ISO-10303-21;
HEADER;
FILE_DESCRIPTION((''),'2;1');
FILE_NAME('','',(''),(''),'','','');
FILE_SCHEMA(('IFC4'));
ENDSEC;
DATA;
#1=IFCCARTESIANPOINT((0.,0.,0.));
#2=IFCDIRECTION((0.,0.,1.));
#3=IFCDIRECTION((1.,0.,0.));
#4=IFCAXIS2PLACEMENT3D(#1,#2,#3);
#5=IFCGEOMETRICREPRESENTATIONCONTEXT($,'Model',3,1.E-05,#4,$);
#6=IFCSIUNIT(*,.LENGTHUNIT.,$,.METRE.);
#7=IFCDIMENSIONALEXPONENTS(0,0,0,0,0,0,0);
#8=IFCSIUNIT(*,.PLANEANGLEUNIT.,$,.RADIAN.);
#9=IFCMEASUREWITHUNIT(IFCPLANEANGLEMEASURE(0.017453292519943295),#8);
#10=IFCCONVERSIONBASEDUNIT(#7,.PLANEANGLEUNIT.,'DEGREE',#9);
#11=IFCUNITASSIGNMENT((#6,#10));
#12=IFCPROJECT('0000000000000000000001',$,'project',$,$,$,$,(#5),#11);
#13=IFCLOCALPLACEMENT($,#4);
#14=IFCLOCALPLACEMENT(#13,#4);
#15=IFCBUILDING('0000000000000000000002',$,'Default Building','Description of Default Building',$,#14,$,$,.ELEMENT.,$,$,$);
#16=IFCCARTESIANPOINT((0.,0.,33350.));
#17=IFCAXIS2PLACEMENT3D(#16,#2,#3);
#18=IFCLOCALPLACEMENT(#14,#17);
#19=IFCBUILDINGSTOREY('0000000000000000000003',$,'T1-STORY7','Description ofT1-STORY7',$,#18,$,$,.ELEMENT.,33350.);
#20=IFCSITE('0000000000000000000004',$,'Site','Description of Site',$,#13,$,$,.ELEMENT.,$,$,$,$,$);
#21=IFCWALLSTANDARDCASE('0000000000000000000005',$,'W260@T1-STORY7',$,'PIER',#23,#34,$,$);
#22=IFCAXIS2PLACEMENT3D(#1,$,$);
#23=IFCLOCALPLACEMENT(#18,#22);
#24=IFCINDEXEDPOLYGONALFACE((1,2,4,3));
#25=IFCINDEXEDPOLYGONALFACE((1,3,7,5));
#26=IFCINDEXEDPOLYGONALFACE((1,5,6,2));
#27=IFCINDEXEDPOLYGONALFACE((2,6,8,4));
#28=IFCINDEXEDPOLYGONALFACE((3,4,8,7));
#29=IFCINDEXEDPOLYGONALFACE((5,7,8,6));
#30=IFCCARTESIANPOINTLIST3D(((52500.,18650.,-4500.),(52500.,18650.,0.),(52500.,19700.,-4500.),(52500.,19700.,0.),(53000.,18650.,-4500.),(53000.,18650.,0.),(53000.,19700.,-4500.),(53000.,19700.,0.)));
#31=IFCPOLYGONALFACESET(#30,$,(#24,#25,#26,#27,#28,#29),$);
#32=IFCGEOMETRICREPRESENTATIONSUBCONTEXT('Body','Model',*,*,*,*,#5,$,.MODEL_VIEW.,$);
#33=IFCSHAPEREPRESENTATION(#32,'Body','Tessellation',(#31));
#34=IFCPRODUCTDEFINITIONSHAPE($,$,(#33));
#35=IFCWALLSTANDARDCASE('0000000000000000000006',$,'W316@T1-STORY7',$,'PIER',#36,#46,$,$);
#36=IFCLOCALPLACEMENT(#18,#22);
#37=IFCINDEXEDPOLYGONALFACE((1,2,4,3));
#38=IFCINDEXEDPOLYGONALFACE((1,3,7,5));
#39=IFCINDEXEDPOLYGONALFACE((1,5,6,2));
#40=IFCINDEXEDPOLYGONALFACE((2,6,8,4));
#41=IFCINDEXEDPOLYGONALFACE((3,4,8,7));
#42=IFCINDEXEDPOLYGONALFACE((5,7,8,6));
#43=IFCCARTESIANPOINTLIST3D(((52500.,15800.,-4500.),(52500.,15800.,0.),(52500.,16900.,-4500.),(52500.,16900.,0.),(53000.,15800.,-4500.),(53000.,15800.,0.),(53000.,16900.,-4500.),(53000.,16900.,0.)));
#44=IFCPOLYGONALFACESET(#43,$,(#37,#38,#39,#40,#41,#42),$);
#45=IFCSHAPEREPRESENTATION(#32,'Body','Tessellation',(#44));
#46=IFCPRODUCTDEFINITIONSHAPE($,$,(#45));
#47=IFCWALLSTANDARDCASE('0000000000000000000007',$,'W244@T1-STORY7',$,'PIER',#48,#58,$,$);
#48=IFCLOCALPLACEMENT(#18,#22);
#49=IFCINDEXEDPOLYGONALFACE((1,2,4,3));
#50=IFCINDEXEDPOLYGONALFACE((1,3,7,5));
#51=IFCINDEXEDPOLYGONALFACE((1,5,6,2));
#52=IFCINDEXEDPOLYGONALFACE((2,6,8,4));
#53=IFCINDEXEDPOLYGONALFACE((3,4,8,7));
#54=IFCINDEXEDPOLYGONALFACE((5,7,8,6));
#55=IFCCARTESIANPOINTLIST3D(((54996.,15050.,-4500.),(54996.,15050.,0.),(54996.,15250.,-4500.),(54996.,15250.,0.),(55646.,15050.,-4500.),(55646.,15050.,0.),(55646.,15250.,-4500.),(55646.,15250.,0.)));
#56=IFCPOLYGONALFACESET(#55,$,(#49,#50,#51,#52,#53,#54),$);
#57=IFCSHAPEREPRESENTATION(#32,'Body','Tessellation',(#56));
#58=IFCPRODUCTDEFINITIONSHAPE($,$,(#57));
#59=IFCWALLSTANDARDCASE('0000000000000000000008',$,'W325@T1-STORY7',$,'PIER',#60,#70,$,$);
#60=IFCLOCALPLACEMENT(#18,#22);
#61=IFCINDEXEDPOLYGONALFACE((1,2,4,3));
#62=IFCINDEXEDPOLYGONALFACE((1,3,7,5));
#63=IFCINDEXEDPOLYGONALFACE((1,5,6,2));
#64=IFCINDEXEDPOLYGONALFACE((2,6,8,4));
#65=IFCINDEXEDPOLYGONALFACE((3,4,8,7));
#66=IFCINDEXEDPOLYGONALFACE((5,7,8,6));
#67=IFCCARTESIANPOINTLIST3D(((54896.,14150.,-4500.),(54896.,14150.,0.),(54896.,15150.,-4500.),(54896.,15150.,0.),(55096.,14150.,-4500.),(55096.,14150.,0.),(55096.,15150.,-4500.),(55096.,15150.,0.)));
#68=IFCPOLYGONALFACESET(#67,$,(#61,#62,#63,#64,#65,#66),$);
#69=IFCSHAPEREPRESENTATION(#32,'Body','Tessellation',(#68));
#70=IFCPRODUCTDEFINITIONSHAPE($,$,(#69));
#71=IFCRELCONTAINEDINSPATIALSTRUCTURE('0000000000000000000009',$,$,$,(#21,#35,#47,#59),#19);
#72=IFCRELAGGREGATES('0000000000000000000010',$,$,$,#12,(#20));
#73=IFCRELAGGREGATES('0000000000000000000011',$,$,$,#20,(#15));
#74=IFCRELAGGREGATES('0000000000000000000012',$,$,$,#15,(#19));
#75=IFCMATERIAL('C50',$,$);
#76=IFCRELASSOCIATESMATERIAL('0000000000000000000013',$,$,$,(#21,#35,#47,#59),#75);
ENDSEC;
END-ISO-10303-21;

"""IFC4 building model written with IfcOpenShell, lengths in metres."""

from ifc_helpers import new_model, entity, si_unit, converted_unit, frame, origin_with_axes, place, context, subcontext, project, spatial, indexed_curve, outline, extrude, material, element, save


model = new_model("IFC4")

# Units and contexts
model_context = context("Model", 3, precision=1e-05, world=origin_with_axes())
body_context = subcontext(model_context, "Body", "Model", "MODEL_VIEW")
ifc_project = project(units=[si_unit("LENGTHUNIT", "METRE"), converted_unit("PLANEANGLEUNIT", "DEGREE", entity("IfcPlaneAngleMeasure", 0.017453292519943295), si_unit("PLANEANGLEUNIT", "RADIAN"), dimensions=[0, 0, 0, 0, 0, 0, 0])], contexts=[model_context])

# Site, building, storey
site_placement = place(None, origin_with_axes())
site = spatial("IfcSite", under=ifc_project, at=site_placement, Name="Site", Description="Description of Site", CompositionType="ELEMENT")
building_placement = place(site_placement, origin_with_axes())
building = spatial("IfcBuilding", under=site, at=building_placement, Name="Default Building", Description="Description of Default Building", CompositionType="ELEMENT")
storey_placement = place(building_placement, frame((0.0, 0.0, 33350.0), z_axis=(0.0, 0.0, 1.0), x_axis=(1.0, 0.0, 0.0)))
storey = spatial("IfcBuildingStorey", under=building, at=storey_placement, Name="T1-STORY7", Description="Description ofT1-STORY7", CompositionType="ELEMENT", Elevation=33350.0)

# Shared definitions
ifc_material_1 = material(Name="C50")

# Walls
wall_1_placement = place(storey_placement, frame((52750.0, 18650.0, -4500.0), z_axis=(0.0, 0.0, 1.0), x_axis=(0.0, 1.0, 0.0)))
element("IfcWallStandardCase", 1, at=wall_1_placement, inside=storey, material=ifc_material_1, Name="W260@T1-STORY7", ObjectType="PIER", context=body_context, shape_type="SweptSolid", body=[
    extrude(outline(indexed_curve([(0.0, -250.0), (0.0, 250.0), (1050.0, 250.0), (1050.0, -250.0), (0.0, -250.0)], self_intersect=False)), origin_with_axes(), (0.0, 0.0, 1.0), 4500.0),
])
wall_2_placement = place(storey_placement, frame((52750.0, 15800.0, -4500.0), z_axis=(0.0, 0.0, 1.0), x_axis=(0.0, 1.0, 0.0)))
element("IfcWallStandardCase", 2, at=wall_2_placement, inside=storey, material=ifc_material_1, Name="W316@T1-STORY7", ObjectType="PIER", context=body_context, shape_type="SweptSolid", body=[
    extrude(outline(indexed_curve([(0.0, -250.0), (0.0, 250.0), (1100.0, 250.0), (1100.0, -250.0), (0.0, -250.0)], self_intersect=False)), origin_with_axes(), (0.0, 0.0, 1.0), 4500.0),
])
wall_3_placement = place(storey_placement, frame((54996.0, 15150.0, -4500.0), z_axis=(0.0, 0.0, 1.0), x_axis=(1.0, 0.0, 0.0)))
element("IfcWallStandardCase", 3, at=wall_3_placement, inside=storey, material=ifc_material_1, Name="W244@T1-STORY7", ObjectType="PIER", context=body_context, shape_type="SweptSolid", body=[
    extrude(outline(indexed_curve([(0.0, -100.0), (0.0, 100.0), (650.0, 100.0), (650.0, -100.0), (0.0, -100.0)], self_intersect=False)), origin_with_axes(), (0.0, 0.0, 1.0), 4500.0),
])
wall_4_placement = place(storey_placement, frame((54996.0, 14150.0, -4500.0), z_axis=(0.0, 0.0, 1.0), x_axis=(0.0, 1.0, 0.0)))
element("IfcWallStandardCase", 4, at=wall_4_placement, inside=storey, material=ifc_material_1, Name="W325@T1-STORY7", ObjectType="PIER", context=body_context, shape_type="SweptSolid", body=[
    extrude(outline(indexed_curve([(0.0, -100.0), (0.0, 100.0), (1000.0, 100.0), (1000.0, -100.0), (0.0, -100.0)], self_intersect=False)), origin_with_axes(), (0.0, 0.0, 1.0), 4500.0),
])

save(model, "model.ifc")
